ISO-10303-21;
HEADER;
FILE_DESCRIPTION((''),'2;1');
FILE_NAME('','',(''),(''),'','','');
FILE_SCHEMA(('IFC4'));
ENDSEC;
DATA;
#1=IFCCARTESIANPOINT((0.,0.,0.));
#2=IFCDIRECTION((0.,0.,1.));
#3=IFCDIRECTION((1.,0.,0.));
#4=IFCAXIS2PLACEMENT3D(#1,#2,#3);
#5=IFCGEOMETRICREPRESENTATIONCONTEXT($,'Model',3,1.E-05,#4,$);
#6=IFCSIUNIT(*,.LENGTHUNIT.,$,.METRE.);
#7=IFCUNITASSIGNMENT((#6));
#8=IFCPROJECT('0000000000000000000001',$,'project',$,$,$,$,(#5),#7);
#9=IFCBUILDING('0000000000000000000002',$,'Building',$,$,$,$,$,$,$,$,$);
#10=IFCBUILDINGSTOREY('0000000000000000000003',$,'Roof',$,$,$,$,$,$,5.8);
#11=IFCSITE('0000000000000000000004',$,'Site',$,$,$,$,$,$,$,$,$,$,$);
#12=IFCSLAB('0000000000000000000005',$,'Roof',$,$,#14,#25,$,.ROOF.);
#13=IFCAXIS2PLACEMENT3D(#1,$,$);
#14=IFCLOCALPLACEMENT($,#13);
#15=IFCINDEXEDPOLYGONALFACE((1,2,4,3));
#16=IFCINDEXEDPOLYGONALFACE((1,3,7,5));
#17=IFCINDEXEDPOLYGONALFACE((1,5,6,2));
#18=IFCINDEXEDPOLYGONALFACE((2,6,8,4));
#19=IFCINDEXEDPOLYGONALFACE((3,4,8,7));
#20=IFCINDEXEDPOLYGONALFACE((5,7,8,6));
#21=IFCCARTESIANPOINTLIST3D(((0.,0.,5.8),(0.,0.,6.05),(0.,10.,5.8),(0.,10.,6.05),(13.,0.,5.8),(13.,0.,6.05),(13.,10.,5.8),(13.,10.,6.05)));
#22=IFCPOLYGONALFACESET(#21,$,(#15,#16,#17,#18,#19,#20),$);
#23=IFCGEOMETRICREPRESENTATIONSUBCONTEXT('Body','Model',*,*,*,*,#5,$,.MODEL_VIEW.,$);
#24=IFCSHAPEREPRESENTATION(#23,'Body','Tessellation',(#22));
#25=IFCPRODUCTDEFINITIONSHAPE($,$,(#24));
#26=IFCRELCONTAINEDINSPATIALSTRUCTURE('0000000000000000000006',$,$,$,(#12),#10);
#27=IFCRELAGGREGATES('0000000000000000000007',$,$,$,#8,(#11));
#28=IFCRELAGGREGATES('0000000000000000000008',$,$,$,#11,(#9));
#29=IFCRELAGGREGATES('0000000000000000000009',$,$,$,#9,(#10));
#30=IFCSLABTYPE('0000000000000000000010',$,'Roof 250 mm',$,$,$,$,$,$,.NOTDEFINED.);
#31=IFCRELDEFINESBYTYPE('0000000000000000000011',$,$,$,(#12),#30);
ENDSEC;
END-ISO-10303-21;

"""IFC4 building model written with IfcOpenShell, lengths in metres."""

from ifc_helpers import new_model, si_unit, frame, origin_with_axes, place, context, subcontext, project, spatial, indexed_curve, outline, extrude, type_object, element, save


model = new_model("IFC4")

# Units and contexts
model_context = context("Model", 3, precision=1e-05, world=origin_with_axes())
body_context = subcontext(model_context, "Body", "Model", "MODEL_VIEW")
ifc_project = project(units=[si_unit("LENGTHUNIT", "METRE")], contexts=[model_context])

# Site, building, storey
site = spatial("IfcSite", under=ifc_project, Name="Site")
building = spatial("IfcBuilding", under=site, Name="Building")
storey = spatial("IfcBuildingStorey", under=building, Name="Roof", Elevation=5.8)

# Slab
slab_type = type_object("IfcSlabType", Name="Roof 250 mm", PredefinedType="NOTDEFINED")
slab_placement = place(None, frame((0.0, 0.0, 5.8), z_axis=(0.0, 0.0, 1.0), x_axis=(1.0, 0.0, 0.0)))
element("IfcSlab", 1, at=slab_placement, inside=storey, type_object=slab_type, Name="Roof", PredefinedType="ROOF", context=body_context, shape_type="SweptSolid", body=[
    extrude(outline(indexed_curve([(0.0, 0.0), (13.0, 0.0), (13.0, 10.0), (0.0, 10.0)])), None, (0.0, 0.0, 1.0), 0.25),
])

save(model, "model.ifc")
